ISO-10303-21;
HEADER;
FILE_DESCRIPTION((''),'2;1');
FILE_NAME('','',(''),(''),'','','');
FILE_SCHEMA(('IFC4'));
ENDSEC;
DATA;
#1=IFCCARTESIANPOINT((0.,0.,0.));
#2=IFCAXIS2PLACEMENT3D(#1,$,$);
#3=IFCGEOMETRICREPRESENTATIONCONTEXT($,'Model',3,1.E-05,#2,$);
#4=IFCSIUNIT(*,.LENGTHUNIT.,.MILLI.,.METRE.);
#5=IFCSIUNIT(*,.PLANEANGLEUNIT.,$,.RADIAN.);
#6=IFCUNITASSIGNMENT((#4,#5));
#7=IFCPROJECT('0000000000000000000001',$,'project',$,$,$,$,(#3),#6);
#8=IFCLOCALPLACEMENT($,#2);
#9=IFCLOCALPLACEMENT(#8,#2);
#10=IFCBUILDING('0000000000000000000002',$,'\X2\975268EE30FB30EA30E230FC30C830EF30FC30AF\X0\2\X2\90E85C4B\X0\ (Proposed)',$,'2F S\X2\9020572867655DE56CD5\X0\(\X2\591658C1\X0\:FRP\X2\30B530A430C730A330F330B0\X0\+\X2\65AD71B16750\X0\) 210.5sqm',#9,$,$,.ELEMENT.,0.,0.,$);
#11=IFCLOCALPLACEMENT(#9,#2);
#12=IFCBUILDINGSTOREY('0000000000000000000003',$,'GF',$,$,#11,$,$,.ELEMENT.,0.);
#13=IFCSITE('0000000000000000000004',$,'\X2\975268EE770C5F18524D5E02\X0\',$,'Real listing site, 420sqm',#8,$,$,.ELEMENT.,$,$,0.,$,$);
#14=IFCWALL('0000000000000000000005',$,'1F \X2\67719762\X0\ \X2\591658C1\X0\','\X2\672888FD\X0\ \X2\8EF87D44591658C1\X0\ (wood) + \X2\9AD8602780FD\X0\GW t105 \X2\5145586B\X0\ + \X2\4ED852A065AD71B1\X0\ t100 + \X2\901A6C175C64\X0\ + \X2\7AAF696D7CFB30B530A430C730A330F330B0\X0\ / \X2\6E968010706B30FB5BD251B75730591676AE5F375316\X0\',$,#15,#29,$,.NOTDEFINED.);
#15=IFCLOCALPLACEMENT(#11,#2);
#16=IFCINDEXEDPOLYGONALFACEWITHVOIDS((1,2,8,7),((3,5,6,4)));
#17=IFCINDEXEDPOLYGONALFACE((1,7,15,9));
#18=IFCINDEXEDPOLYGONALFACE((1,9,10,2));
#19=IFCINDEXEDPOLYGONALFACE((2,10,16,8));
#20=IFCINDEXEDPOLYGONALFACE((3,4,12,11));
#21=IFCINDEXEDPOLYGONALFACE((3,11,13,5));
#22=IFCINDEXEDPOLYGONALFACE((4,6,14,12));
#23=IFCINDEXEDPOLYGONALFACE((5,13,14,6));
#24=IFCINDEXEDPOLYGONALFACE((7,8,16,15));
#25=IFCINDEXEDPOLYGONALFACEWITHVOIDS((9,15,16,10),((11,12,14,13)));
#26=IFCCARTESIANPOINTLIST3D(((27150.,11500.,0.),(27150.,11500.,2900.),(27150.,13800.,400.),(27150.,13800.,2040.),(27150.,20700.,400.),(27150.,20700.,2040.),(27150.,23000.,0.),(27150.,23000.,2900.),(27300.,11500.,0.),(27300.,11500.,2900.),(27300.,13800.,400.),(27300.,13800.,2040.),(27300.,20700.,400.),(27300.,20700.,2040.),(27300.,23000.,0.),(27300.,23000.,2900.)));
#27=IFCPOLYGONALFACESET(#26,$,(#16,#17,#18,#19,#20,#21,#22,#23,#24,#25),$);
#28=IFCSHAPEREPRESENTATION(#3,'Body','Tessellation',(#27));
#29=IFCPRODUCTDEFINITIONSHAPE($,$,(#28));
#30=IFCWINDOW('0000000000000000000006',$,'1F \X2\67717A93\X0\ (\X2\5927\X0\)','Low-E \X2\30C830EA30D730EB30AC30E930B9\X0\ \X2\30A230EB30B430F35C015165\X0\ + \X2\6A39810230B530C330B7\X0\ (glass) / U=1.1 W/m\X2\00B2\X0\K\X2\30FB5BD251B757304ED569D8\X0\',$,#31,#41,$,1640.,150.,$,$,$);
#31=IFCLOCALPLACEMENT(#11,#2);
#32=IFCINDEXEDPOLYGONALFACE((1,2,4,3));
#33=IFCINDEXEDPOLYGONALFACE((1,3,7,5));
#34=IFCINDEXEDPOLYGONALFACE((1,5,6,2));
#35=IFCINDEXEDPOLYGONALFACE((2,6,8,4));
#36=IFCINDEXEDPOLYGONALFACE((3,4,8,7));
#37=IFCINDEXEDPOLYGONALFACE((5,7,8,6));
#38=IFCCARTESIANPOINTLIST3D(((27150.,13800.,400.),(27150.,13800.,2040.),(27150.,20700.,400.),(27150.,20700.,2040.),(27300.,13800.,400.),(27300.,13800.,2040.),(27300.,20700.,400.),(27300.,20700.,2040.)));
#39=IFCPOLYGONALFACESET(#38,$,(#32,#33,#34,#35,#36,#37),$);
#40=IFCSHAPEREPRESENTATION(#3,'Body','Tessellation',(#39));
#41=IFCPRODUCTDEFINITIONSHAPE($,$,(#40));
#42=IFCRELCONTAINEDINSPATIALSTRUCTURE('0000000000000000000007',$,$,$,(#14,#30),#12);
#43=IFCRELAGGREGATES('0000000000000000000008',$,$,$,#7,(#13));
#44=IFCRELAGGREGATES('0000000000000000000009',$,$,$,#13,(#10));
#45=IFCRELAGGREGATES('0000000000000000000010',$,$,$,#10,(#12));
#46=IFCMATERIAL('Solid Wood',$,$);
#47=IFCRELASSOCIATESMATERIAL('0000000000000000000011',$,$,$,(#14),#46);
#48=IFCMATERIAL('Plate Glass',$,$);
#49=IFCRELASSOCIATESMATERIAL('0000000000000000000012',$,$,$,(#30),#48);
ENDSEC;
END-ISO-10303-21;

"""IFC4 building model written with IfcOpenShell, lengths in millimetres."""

from ifc_helpers import new_model, si_unit, frame, frame_2d, origin, place, context, project, spatial, rectangle, extrude, material, element, fill, save


model = new_model("IFC4")

# Units and contexts
model_context = context("Model", 3, precision=1e-05, world=origin())
ifc_project = project(units=[si_unit("LENGTHUNIT", "METRE", prefix="MILLI"), si_unit("PLANEANGLEUNIT", "RADIAN")], contexts=[model_context])

# Site, building, storey
site_placement = place(None, origin())
site = spatial("IfcSite", under=ifc_project, at=site_placement, Name="青森県弘前市", ObjectType="Real listing site, 420sqm", CompositionType="ELEMENT", RefElevation=0.0)
building_placement = place(site_placement, origin())
building = spatial("IfcBuilding", under=site, at=building_placement, Name="青森・リモートワーク2部屋 (Proposed)", ObjectType="2F S造在来工法(外壁:FRPサイディング+断熱材) 210.5sqm", CompositionType="ELEMENT", ElevationOfRefHeight=0.0, ElevationOfTerrain=0.0)
storey_placement = place(building_placement, origin())
storey = spatial("IfcBuildingStorey", under=building, at=storey_placement, Name="GF", CompositionType="ELEMENT", Elevation=0.0)

# Shared definitions
ifc_material_1 = material(Name="Solid Wood")

# Wall, opening, window
wall_1_placement = place(storey_placement, frame((13575.0, 5750.0, 0.0)))
wall_1 = element("IfcWall", 1, at=wall_1_placement, inside=storey, material=ifc_material_1, Name="1F 東面 外壁", Description="木製 軸組外壁 (wood) + 高性能GW t105 充填 + 付加断熱 t100 + 通気層 + 窯業系サイディング / 準耐火・寒冷地外皮強化", PredefinedType="NOTDEFINED", context=model_context, shape_type="SweptSolid", body=[
    extrude(rectangle(XDim=150.0, YDim=11500.0, at=frame_2d((75.0, 5750.0))), frame((13575.0, 5750.0, 0.0)), (0.0, 0.0, 1.0), 2900.0),
])
opening_1_placement = place(storey_placement, frame((13575.0, 6900.0, 200.0)))
opening_1 = element("IfcOpeningElement", 2, at=opening_1_placement, cuts=wall_1, PredefinedType="NOTDEFINED", context=model_context, shape_type="SweptSolid", body=[
    extrude(rectangle(XDim=150.0, YDim=6900.0, at=frame_2d((75.0, 3450.0))), frame((13575.0, 6900.0, 200.0)), (0.0, 0.0, 1.0), 1640.0),
])
ifc_material_2 = material(Name="Plate Glass")
window_1_placement = place(storey_placement, frame((13575.0, 6900.0, 200.0)))
window_1 = element("IfcWindow", 3, at=window_1_placement, inside=storey, material=ifc_material_2, Name="1F 東窓 (大)", Description="Low-E トリプルガラス アルゴン封入 + 樹脂サッシ (glass) / U=1.1 W/m²K・寒冷地仕様", OverallHeight=1640.0, OverallWidth=150.0, context=model_context, shape_type="SweptSolid", body=[
    extrude(rectangle(XDim=150.0, YDim=6900.0, at=frame_2d((75.0, 3450.0))), frame((13575.0, 6900.0, 200.0)), (0.0, 0.0, 1.0), 1640.0),
])
fill(opening_1, window_1)

save(model, "model.ifc")
